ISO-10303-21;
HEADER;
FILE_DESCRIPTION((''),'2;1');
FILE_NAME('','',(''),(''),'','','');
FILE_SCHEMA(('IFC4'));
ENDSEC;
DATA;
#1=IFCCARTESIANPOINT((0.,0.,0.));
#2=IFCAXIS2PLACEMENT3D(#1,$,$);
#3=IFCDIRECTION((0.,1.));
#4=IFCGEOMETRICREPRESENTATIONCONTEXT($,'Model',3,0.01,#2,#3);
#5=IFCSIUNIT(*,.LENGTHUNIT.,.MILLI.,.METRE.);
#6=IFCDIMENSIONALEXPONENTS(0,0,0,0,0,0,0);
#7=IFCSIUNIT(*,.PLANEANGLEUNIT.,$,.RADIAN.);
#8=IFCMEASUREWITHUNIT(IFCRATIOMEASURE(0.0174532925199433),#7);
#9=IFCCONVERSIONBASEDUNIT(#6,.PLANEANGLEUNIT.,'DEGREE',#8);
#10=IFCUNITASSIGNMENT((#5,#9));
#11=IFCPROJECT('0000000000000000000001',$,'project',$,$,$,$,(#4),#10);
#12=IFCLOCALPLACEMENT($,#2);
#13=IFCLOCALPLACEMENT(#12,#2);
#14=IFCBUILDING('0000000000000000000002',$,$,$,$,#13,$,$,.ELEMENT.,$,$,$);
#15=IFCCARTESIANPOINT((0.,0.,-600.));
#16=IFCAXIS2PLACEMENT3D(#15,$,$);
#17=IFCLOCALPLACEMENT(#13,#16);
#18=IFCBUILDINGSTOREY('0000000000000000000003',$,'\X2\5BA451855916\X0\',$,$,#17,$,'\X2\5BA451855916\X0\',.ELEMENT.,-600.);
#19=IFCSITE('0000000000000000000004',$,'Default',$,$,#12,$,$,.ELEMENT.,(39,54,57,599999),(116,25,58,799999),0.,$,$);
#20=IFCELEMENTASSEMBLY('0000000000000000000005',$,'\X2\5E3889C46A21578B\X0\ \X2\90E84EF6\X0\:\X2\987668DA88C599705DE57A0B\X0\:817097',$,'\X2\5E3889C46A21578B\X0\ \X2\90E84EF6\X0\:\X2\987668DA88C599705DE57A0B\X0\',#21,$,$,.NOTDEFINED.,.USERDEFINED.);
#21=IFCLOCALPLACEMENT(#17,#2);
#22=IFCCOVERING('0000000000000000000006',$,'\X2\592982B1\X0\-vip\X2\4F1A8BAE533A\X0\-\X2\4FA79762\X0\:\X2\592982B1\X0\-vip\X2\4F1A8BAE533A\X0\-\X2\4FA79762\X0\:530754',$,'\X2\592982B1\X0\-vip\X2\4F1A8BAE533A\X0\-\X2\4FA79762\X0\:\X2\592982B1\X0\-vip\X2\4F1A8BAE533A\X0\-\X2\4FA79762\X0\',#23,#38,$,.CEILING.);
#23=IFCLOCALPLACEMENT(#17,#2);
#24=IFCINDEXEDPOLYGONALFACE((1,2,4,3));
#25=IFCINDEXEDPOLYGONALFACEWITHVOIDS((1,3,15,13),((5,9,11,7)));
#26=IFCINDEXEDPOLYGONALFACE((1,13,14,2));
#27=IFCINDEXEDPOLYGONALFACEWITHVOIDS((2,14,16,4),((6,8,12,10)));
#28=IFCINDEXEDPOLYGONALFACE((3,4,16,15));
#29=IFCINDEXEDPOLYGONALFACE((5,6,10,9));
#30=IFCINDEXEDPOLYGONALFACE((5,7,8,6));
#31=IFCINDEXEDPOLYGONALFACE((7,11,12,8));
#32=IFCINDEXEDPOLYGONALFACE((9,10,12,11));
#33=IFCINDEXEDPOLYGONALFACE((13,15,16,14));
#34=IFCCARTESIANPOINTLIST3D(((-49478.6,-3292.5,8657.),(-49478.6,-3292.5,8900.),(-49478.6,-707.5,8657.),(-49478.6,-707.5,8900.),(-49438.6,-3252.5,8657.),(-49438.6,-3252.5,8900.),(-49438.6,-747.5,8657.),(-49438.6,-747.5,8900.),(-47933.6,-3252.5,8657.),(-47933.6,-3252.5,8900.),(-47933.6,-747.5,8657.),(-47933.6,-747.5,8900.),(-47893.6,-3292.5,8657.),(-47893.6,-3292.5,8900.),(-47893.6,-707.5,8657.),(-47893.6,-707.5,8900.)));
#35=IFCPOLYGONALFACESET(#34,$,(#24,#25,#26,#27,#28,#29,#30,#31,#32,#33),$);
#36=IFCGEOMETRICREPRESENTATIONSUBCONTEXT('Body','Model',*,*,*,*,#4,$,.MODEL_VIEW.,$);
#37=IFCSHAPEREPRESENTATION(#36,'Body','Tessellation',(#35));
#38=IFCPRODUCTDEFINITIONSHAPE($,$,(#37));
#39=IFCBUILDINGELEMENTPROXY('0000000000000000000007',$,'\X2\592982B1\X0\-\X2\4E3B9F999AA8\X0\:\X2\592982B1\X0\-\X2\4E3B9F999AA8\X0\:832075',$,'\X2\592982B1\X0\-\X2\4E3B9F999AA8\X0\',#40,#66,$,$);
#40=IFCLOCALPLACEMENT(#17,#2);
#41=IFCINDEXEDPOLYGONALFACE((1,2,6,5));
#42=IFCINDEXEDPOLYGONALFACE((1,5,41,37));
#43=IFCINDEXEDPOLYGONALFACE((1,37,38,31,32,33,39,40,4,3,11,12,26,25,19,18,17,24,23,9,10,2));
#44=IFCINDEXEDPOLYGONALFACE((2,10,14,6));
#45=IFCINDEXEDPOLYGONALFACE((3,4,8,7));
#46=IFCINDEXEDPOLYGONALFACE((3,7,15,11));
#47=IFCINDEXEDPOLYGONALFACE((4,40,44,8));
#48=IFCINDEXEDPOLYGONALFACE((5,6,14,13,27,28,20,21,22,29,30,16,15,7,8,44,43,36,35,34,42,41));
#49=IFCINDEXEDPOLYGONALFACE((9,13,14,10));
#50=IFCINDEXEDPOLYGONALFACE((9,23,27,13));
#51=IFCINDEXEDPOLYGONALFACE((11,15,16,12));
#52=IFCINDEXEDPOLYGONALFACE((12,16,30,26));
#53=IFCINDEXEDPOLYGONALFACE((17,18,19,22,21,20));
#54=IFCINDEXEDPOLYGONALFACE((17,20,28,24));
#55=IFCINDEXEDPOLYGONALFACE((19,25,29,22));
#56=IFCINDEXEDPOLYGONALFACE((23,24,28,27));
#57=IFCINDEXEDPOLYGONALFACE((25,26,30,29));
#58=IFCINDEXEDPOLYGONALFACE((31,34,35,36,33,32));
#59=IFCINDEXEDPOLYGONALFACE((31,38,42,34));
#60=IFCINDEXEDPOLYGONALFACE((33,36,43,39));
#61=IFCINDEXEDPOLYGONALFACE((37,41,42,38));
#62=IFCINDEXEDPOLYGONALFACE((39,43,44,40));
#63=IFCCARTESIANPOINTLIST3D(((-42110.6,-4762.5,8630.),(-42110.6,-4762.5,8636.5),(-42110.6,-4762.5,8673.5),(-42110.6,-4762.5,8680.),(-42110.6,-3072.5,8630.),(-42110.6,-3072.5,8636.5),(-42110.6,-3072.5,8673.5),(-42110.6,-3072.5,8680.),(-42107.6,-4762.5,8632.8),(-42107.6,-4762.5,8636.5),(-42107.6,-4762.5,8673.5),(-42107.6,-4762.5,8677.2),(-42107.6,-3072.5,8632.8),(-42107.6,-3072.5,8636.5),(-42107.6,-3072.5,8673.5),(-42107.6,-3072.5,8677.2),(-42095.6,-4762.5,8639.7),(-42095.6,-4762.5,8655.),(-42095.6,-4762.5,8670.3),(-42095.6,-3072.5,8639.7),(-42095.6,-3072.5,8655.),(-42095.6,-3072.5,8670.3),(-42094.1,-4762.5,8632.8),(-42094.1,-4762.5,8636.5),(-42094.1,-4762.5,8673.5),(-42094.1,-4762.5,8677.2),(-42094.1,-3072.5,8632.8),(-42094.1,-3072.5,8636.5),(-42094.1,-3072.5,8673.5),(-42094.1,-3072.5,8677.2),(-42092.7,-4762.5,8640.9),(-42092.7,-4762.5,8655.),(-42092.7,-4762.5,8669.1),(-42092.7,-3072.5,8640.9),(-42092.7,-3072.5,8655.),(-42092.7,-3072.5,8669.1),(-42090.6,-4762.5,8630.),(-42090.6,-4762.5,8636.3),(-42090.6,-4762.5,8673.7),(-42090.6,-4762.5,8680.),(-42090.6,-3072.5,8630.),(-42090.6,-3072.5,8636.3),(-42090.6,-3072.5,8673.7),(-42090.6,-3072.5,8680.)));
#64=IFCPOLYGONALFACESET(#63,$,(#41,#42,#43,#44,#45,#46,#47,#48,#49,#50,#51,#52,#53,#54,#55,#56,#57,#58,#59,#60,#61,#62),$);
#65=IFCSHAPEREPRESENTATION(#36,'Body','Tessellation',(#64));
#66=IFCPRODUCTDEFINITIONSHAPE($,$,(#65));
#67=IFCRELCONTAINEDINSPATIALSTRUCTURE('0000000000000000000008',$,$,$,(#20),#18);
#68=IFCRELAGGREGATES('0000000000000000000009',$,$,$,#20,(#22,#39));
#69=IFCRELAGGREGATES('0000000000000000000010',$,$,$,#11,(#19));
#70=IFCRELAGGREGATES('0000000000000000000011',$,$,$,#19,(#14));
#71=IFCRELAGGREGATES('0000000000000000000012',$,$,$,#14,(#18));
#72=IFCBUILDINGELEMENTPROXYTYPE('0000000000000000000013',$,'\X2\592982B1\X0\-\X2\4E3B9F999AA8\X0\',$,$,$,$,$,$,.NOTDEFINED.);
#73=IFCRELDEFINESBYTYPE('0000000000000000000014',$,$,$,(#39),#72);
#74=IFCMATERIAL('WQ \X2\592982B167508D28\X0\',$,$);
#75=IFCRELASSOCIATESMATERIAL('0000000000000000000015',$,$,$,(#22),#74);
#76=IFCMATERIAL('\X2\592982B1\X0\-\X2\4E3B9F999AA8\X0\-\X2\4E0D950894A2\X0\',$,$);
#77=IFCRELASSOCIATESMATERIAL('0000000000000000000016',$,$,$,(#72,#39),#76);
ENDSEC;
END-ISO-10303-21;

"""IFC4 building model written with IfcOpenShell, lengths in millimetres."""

from ifc_helpers import new_model, entity, si_unit, converted_unit, direction, frame, origin, place, context, subcontext, project, spatial, polyline, outline, extrude, source, transform, mapped, material, type_object, type_shapes, element, aggregate, save


model = new_model("IFC4")

# Units and contexts
model_context = context("Model", 3, precision=0.01, world=origin(), true_north=direction((0.0, 1.0)))
body_context = subcontext(model_context, "Body", "Model", "MODEL_VIEW")
ifc_project = project(units=[si_unit("LENGTHUNIT", "METRE", prefix="MILLI"), converted_unit("PLANEANGLEUNIT", "DEGREE", entity("IfcRatioMeasure", 0.0174532925199433), si_unit("PLANEANGLEUNIT", "RADIAN"), dimensions=[0, 0, 0, 0, 0, 0, 0])], contexts=[model_context])

# Site, building, storey
site_placement = place(None, origin())
site = spatial("IfcSite", under=ifc_project, at=site_placement, Name="Default", CompositionType="ELEMENT", RefLatitude=(39, 54, 57, 599999), RefLongitude=(116, 25, 58, 799999), RefElevation=0.0)
building_placement = place(site_placement, origin())
building = spatial("IfcBuilding", under=site, at=building_placement, CompositionType="ELEMENT")
storey_placement = place(building_placement, frame((0.0, 0.0, -600.0)))
storey = spatial("IfcBuildingStorey", under=building, at=storey_placement, Name="室内外", LongName="室内外", CompositionType="ELEMENT", Elevation=-600.0)

# Element assembly, covering, building element proxy
assembly_placement = place(storey_placement, origin())
assembly = element("IfcElementAssembly", 1, at=assembly_placement, inside=storey, Name="常规模型 部件:顶棚装饰工程:817097", ObjectType="常规模型 部件:顶棚装饰工程", AssemblyPlace="NOTDEFINED", PredefinedType="USERDEFINED")
ifc_material_1 = material(Name="WQ 天花材质")
covering_1_placement = place(assembly_placement, frame((-49478.6, -3292.5, 8657.0)))
covering_1 = element("IfcCovering", 2, at=covering_1_placement, material=ifc_material_1, Name="天花-vip会议区-侧面:天花-vip会议区-侧面:530754", ObjectType="天花-vip会议区-侧面:天花-vip会议区-侧面", PredefinedType="CEILING", context=body_context, shape_type="SweptSolid", body=[
    extrude(outline(polyline([(-1292.5, -792.5), (1292.5, -792.5), (1292.5, 792.5), (-1292.5, 792.5), (-1292.5, -792.5)]), holes=[polyline([(-1252.5, -752.5), (-1252.5, 752.5), (1252.5, 752.5), (1252.5, -752.5), (-1252.5, -752.5)])]), frame((792.5, 1292.5, 0.0), z_axis=(0.0, 0.0, 1.0), x_axis=(0.0, 1.0, 0.0)), (0.0, 0.0, 1.0), 243.0),
])
ifc_material_2 = material(Name="天花-主龙骨-不锈钢")
building_element_proxy_type_1 = type_object("IfcBuildingElementProxyType", Name="天花-主龙骨", PredefinedType="NOTDEFINED", material=ifc_material_2)
shared_shape_1 = source(origin(), body_context, "Body", "SweptSolid", [
    extrude(outline(polyline([(-25.0, -11.7), (-18.5, -11.7), (-18.5, -8.7), (-22.2, -8.7), (-22.2, 4.8), (-18.5, 4.8), (-15.3, 3.3), (0.0, 3.3), (15.3, 3.3), (18.5, 4.8), (22.2, 4.8), (22.2, -8.7), (18.5, -8.7), (18.5, -11.7), (25.0, -11.7), (25.0, 8.3), (18.7, 8.3), (14.1, 6.2), (0.0, 6.2), (-14.1, 6.2), (-18.7, 8.3), (-25.0, 8.3), (-25.0, -11.7)])), frame((0.0, 1.7, 0.0), z_axis=(1.0, 0.0, 0.0), x_axis=(0.0, 0.0, -1.0)), (0.0, 0.0, 1.0), 1690.0),
])
type_shapes(building_element_proxy_type_1, [shared_shape_1])
proxy_1_placement = place(assembly_placement, frame((-42100.6, -3072.5, 8655.0), z_axis=(0.0, 0.0, 1.0), x_axis=(0.0, -1.0, 0.0)))
proxy_1 = element("IfcBuildingElementProxy", 3, at=proxy_1_placement, type_object=building_element_proxy_type_1, material=ifc_material_2, Name="天花-主龙骨:天花-主龙骨:832075", ObjectType="天花-主龙骨", context=body_context, shape_type="MappedRepresentation", body=[
    mapped(shared_shape_1, transform((0.0, 0.0, 0.0), scale=1.0)),
])
aggregate(assembly, [covering_1, proxy_1])

save(model, "model.ifc")
